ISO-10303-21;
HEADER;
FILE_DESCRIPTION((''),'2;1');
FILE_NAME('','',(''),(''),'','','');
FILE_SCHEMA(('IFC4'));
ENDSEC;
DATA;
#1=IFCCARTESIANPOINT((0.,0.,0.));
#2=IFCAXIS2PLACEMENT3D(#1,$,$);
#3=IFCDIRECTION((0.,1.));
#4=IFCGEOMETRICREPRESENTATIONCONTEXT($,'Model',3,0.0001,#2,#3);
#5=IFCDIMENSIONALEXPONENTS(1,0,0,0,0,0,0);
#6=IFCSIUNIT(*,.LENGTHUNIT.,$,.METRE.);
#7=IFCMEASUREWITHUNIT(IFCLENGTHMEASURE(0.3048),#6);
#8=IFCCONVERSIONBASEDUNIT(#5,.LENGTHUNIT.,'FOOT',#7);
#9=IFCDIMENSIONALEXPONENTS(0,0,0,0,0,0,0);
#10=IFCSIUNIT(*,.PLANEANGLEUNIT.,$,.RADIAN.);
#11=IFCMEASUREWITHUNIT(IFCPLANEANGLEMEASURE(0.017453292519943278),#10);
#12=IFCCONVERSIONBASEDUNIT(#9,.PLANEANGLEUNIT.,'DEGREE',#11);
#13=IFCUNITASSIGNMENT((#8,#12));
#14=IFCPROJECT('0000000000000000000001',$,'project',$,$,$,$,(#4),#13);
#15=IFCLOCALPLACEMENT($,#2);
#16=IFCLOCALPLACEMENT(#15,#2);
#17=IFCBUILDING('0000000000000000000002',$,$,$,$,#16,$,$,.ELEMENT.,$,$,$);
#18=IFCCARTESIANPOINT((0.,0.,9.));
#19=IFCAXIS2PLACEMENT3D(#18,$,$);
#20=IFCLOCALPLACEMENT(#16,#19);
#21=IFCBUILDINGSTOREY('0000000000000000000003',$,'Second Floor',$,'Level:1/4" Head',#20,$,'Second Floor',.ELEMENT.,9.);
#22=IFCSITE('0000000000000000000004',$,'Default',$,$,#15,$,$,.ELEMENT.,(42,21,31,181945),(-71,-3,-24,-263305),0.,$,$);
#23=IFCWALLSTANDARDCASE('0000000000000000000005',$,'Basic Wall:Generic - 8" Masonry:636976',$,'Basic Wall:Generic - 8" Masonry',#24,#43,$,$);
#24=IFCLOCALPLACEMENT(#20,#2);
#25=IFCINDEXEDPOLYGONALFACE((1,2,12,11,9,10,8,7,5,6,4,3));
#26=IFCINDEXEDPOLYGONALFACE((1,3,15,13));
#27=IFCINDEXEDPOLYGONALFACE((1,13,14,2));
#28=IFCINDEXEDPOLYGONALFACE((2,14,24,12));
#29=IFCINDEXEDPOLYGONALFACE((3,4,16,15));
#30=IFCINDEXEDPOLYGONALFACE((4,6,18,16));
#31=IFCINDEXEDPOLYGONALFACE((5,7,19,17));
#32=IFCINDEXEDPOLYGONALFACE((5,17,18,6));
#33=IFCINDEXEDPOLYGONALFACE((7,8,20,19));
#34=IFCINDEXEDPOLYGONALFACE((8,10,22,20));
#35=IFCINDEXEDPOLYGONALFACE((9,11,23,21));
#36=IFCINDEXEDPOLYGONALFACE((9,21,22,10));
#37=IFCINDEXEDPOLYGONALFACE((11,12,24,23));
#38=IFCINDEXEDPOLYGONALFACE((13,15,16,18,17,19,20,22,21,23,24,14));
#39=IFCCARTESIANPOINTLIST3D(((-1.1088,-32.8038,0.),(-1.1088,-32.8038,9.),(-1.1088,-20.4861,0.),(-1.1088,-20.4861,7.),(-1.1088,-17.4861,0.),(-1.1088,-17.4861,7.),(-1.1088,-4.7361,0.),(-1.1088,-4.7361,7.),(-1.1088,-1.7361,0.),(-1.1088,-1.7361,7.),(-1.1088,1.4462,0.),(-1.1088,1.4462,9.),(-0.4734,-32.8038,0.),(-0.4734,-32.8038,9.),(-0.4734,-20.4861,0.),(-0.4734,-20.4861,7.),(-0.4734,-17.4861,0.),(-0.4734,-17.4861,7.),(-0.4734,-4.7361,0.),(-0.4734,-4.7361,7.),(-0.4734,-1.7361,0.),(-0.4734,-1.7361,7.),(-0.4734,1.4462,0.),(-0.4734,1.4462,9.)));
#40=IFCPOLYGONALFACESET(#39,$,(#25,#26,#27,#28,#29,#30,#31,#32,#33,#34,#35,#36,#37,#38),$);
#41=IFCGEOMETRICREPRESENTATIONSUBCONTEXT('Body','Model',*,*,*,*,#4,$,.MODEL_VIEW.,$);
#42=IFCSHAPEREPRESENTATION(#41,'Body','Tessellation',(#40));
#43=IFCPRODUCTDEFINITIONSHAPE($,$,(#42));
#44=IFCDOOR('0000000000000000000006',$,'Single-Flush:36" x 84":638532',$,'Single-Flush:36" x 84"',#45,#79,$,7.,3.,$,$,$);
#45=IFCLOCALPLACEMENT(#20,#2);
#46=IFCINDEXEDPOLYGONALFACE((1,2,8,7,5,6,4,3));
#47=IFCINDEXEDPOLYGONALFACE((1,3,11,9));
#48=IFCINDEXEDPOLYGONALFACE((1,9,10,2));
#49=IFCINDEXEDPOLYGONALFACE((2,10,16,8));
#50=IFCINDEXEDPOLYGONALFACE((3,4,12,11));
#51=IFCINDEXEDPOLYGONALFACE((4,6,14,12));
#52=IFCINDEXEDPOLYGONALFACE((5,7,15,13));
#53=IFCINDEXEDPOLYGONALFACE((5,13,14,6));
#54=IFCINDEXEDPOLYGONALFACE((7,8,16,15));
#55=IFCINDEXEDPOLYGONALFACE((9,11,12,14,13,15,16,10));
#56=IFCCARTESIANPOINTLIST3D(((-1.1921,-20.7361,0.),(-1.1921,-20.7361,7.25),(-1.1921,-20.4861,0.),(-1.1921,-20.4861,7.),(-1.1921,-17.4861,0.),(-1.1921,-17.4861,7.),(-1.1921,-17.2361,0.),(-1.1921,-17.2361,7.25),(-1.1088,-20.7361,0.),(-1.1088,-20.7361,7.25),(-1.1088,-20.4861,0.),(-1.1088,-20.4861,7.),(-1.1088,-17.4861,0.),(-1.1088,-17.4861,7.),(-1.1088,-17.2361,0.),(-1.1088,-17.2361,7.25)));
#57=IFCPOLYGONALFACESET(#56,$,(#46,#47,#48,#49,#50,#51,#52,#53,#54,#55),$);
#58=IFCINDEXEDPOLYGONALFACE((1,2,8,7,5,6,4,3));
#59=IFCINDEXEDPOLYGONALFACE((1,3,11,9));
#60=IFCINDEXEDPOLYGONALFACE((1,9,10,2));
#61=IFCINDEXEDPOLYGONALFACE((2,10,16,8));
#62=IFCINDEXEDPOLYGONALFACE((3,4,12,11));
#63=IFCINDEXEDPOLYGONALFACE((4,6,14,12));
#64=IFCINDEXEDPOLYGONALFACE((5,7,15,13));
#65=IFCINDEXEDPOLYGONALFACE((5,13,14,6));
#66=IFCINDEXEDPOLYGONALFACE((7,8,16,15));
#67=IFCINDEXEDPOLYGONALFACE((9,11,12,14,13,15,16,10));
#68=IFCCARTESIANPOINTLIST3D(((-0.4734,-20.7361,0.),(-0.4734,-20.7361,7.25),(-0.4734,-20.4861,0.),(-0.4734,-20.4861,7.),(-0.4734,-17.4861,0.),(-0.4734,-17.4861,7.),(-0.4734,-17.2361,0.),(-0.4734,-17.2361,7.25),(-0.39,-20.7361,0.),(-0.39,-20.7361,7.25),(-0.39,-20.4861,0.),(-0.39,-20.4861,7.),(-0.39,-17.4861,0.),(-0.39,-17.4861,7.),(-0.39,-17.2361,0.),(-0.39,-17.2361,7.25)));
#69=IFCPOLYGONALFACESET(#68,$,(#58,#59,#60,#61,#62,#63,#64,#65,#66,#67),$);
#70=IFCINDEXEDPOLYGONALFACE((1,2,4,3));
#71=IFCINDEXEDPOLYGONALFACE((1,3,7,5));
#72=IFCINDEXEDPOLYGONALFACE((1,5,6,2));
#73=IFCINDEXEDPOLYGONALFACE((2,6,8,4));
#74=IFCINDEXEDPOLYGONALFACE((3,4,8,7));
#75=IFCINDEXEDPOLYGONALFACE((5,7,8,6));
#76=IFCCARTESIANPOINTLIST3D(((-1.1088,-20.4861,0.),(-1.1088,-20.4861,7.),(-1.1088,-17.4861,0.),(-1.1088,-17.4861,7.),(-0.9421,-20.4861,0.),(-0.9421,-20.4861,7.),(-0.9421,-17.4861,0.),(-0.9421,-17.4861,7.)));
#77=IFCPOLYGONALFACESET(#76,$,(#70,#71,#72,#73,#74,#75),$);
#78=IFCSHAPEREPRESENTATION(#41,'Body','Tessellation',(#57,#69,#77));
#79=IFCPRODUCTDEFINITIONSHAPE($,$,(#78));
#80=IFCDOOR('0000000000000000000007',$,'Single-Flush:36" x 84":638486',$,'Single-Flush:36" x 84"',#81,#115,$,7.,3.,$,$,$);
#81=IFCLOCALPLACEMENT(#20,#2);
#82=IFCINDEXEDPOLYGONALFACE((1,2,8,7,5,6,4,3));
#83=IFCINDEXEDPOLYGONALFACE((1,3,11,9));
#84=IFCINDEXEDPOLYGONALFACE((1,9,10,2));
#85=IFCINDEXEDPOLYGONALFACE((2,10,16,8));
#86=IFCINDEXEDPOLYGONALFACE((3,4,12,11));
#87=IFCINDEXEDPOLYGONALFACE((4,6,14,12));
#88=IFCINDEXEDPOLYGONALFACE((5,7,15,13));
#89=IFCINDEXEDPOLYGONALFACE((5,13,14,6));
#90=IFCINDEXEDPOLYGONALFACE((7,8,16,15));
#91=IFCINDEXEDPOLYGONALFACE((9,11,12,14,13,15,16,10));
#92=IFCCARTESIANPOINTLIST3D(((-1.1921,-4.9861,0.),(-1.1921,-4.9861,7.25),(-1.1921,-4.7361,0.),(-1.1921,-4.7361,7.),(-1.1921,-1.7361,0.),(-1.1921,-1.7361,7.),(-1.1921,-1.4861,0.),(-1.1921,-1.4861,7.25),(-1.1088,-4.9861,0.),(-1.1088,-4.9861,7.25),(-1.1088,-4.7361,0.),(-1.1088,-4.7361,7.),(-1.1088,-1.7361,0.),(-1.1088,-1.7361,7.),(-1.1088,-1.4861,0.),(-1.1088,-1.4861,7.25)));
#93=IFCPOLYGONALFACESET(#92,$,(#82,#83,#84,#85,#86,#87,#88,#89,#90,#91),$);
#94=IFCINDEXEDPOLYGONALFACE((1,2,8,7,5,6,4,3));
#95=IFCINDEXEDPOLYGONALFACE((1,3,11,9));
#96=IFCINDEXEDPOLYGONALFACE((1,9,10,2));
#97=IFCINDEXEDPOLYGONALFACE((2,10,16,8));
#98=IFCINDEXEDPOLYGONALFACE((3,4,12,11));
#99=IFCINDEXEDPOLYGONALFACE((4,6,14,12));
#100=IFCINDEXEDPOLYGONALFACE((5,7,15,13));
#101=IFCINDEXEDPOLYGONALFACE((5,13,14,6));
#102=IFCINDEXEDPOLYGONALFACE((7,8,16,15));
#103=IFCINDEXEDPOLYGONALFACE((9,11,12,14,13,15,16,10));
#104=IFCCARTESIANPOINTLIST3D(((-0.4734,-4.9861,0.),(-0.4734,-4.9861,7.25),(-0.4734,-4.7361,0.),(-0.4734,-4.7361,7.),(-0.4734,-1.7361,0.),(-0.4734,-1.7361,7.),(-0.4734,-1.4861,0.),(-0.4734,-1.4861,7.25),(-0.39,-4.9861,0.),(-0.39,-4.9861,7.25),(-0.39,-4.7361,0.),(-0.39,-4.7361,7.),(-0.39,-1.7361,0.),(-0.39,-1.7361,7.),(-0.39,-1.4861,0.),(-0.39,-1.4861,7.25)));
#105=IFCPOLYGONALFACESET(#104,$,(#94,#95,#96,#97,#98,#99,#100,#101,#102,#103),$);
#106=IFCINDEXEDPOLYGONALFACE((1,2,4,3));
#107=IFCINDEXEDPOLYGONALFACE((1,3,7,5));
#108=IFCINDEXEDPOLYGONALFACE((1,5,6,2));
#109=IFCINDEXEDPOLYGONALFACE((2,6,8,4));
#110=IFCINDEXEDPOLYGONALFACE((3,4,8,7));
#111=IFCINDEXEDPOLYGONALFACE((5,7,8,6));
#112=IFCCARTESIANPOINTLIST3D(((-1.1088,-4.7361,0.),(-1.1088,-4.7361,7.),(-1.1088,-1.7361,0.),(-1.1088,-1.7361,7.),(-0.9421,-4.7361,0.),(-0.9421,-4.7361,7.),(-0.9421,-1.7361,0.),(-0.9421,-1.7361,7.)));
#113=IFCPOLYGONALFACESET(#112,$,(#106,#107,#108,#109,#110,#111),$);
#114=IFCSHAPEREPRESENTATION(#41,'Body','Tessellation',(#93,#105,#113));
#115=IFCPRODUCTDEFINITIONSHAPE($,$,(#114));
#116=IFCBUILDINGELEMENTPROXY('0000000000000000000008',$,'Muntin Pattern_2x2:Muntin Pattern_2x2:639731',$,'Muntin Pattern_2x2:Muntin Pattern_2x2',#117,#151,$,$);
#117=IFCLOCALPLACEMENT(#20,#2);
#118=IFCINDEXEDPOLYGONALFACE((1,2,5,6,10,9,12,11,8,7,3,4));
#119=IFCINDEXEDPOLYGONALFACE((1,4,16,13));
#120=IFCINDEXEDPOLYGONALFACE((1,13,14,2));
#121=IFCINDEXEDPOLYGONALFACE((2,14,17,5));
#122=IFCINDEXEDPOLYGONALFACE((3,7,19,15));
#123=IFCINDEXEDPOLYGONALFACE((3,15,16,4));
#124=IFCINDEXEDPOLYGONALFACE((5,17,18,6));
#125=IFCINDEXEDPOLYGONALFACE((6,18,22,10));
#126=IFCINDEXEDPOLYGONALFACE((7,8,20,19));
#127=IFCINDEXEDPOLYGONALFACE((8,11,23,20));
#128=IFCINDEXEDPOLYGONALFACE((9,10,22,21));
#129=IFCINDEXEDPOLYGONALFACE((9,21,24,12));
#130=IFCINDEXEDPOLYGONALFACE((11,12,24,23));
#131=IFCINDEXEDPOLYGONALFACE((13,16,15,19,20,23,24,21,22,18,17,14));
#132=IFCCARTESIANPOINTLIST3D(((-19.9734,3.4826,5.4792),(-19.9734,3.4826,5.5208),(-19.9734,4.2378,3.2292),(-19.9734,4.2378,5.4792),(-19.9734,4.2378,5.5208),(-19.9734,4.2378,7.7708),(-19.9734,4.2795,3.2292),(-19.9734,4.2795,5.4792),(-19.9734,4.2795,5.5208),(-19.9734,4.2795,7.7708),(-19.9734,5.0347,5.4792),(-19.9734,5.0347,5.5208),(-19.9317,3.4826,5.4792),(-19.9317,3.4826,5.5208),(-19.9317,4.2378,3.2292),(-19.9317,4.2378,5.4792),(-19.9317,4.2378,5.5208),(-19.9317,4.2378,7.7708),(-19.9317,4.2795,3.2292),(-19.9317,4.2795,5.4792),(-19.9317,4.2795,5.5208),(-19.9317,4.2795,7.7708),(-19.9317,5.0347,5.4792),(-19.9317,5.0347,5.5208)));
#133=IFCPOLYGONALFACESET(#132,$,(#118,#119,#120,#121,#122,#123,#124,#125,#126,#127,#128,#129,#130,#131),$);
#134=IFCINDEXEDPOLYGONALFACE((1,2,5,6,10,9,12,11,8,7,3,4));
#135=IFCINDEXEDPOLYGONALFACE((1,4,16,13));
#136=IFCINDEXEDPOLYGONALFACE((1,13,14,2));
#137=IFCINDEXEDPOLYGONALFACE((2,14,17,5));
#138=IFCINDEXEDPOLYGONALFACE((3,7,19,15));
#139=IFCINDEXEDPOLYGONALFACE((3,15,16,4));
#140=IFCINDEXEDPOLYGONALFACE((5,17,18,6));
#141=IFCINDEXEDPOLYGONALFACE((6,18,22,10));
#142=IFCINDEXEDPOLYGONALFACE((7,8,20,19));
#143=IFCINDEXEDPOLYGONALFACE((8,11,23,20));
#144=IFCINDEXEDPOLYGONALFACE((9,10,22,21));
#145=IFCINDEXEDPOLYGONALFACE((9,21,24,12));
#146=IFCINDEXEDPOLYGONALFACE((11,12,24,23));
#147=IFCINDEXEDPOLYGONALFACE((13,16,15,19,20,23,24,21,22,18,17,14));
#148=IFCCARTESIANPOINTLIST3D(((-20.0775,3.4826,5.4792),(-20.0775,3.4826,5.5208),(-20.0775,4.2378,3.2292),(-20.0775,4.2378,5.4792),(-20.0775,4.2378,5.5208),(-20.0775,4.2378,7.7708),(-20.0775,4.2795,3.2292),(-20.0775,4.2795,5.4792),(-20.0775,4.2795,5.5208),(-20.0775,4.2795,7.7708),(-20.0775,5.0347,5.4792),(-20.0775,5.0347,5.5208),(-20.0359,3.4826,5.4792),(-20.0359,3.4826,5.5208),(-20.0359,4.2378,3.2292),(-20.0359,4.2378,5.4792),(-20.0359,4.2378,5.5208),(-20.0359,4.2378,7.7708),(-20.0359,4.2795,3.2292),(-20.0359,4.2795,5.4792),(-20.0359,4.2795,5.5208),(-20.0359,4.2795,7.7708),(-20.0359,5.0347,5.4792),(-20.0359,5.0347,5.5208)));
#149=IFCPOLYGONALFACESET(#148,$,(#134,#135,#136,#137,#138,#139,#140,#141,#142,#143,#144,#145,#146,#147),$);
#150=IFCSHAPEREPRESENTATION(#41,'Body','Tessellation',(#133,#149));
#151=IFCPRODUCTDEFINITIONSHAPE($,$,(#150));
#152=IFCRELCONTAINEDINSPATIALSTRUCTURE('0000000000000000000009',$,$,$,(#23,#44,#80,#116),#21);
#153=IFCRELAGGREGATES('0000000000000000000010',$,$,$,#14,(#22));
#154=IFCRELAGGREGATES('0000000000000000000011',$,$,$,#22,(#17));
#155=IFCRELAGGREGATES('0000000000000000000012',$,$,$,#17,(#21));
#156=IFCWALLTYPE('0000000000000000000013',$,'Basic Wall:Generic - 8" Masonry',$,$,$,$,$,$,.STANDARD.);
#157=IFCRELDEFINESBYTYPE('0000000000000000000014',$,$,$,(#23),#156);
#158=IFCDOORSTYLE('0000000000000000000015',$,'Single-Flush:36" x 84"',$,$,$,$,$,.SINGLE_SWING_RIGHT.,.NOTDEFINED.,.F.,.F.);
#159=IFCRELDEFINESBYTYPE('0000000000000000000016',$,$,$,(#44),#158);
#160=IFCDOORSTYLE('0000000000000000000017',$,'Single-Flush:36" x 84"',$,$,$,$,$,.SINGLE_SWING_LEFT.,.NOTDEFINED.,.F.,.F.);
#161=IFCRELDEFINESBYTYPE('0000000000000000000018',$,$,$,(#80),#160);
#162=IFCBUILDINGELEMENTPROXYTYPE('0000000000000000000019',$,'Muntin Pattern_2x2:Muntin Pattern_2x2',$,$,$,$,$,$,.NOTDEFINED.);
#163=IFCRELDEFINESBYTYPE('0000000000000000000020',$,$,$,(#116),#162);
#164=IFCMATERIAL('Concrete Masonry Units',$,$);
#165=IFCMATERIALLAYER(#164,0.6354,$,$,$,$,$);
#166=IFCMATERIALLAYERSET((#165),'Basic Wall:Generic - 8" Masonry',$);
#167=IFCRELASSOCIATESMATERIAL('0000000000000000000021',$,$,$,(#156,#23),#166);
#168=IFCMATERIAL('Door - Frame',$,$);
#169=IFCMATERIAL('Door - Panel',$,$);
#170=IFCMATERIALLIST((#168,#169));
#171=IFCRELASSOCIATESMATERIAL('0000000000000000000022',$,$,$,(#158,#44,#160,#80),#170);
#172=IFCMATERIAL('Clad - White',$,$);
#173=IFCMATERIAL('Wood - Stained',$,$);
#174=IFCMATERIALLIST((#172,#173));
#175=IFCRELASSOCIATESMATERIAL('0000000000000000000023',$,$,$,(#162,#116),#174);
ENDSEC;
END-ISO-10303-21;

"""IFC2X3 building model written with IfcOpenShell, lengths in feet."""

from ifc_helpers import new_model, entity, si_unit, converted_unit, direction, frame, frame_2d, origin, place, context, subcontext, project, spatial, polyline, rectangle, outline, extrude, source, transform, mapped, material, material_list, layer, layer_set, layer_usage, type_object, type_shapes, element, fill, save


model = new_model("IFC2X3")

# Units and contexts
model_context = context("Model", 3, precision=0.0001, world=origin(), true_north=direction((0.0, 1.0)))
body_context = subcontext(model_context, "Body", "Model", "MODEL_VIEW")
ifc_project = project(units=[converted_unit("LENGTHUNIT", "FOOT", entity("IfcLengthMeasure", 0.3048), si_unit("LENGTHUNIT", "METRE"), dimensions=[1, 0, 0, 0, 0, 0, 0]), converted_unit("PLANEANGLEUNIT", "DEGREE", entity("IfcPlaneAngleMeasure", 0.017453292519943278), si_unit("PLANEANGLEUNIT", "RADIAN"), dimensions=[0, 0, 0, 0, 0, 0, 0])], contexts=[model_context])

# Site, building, storey
site_placement = place(None, origin())
site = spatial("IfcSite", under=ifc_project, at=site_placement, Name="Default", CompositionType="ELEMENT", RefLatitude=(42, 21, 31, 181945), RefLongitude=(-71, -3, -24, -263305), RefElevation=0.0)
building_placement = place(site_placement, origin())
building = spatial("IfcBuilding", under=site, at=building_placement, CompositionType="ELEMENT")
storey_placement = place(building_placement, frame((0.0, 0.0, 9.0)))
storey = spatial("IfcBuildingStorey", under=building, at=storey_placement, Name="Second Floor", ObjectType="Level:1/4\" Head", LongName="Second Floor", CompositionType="ELEMENT", Elevation=9.0)

# Shared definitions
ifc_material_1 = material(Name="Concrete Masonry Units")
ifc_layer = layer(ifc_material_1, 0.6354)
ifc_layer_set = layer_set([ifc_layer], Name="Basic Wall:Generic - 8\" Masonry")
wall_type = type_object("IfcWallType", Name="Basic Wall:Generic - 8\" Masonry", PredefinedType="STANDARD", material=ifc_layer_set)

# Shared definitions
ifc_material_2 = material(Name="Door - Frame")
ifc_material_3 = material(Name="Door - Panel")
ifc_material_list_1 = material_list([ifc_material_2, ifc_material_3])
door_style_1 = type_object("IfcDoorStyle", Name="Single-Flush:36\" x 84\"", ConstructionType="NOTDEFINED", OperationType="SINGLE_SWING_RIGHT", ParameterTakesPrecedence=False, Sizeable=False, material=ifc_material_list_1)
shared_shape_1 = source(origin(), body_context, "Body", "SweptSolid", [
    extrude(outline(polyline([(-1.75, -3.6875), (1.75, -3.6875), (1.75, 3.5625), (1.5, 3.5625), (1.5, -3.4375), (-1.5, -3.4375), (-1.5, 3.5625), (-1.75, 3.5625), (-1.75, -3.6875)])), frame((1.5, 0.6354, 3.5625), z_axis=(0.0, 1.0, 0.0), x_axis=(1.0, 0.0, 0.0)), (0.0, 0.0, 1.0), 0.0833),
    extrude(outline(polyline([(-3.6875, -1.75), (3.5625, -1.75), (3.5625, -1.5), (-3.4375, -1.5), (-3.4375, 1.5), (3.5625, 1.5), (3.5625, 1.75), (-3.6875, 1.75), (-3.6875, -1.75)])), frame((1.5, -0.0833, 3.5625), z_axis=(0.0, 1.0, 0.0), x_axis=(0.0, 0.0, -1.0)), (0.0, 0.0, 1.0), 0.0833),
    extrude(rectangle(XDim=0.1667, YDim=3.0, at=frame_2d((0.0, 0.0), x_axis=(1.0, 0.0))), frame((1.5, 0.5521, 0.0), z_axis=(0.0, 0.0, 1.0), x_axis=(0.0, 1.0, 0.0)), (0.0, 0.0, 1.0), 7.0),
])
type_shapes(door_style_1, [shared_shape_1])

# Wall, openings, doors
ifc_layer_usage_1 = layer_usage(ifc_layer_set, "AXIS2", "NEGATIVE", 0.3177)
wall_1_placement = place(storey_placement, frame((-0.7911, 1.4462, 0.0), z_axis=(0.0, 0.0, 1.0), x_axis=(0.0, -1.0, 0.0)))
wall_1 = element("IfcWallStandardCase", 1, at=wall_1_placement, inside=storey, type_object=wall_type, material=ifc_layer_usage_1, Name="Basic Wall:Generic - 8\" Masonry:636976", ObjectType="Basic Wall:Generic - 8\" Masonry", context=body_context, shape_type="SweptSolid", body=[
    extrude(rectangle(XDim=34.25, YDim=0.6354, at=frame_2d((17.125, 0.0), x_axis=(1.0, 0.0))), origin(), (0.0, 0.0, 1.0), 9.0),
])
opening_1_placement = place(wall_1_placement, frame((6.1823, 0.3177, 0.0)))
opening_1 = element("IfcOpeningElement", 2, at=opening_1_placement, cuts=wall_1, ObjectType="Opening", context=body_context, shape_type="SweptSolid", body=[
    extrude(rectangle(XDim=3.0, YDim=7.0, at=frame_2d((3.5, 1.5), x_axis=(0.0, -1.0))), frame((0.0, 0.0, 0.0), z_axis=(0.0, -1.0, 0.0), x_axis=(0.0, 0.0, 1.0)), (0.0, 0.0, 1.0), 0.6354),
])
opening_2_placement = place(wall_1_placement, frame((21.9323, 0.3177, 0.0)))
opening_2 = element("IfcOpeningElement", 3, at=opening_2_placement, cuts=wall_1, ObjectType="Opening", context=body_context, shape_type="SweptSolid", body=[
    extrude(rectangle(XDim=3.0, YDim=7.0, at=frame_2d((3.5, 1.5), x_axis=(0.0, 1.0))), frame((0.0, 0.0, 0.0), z_axis=(0.0, -1.0, 0.0), x_axis=(0.0, 0.0, 1.0)), (0.0, 0.0, 1.0), 0.6354),
])
door_1_placement = place(opening_2_placement, frame((0.0, 0.0, 0.0), z_axis=(0.0, 0.0, 1.0), x_axis=(-1.0, 0.0, 0.0)))
door_1 = element("IfcDoor", 4, at=door_1_placement, inside=storey, type_object=door_style_1, material=ifc_material_list_1, Name="Single-Flush:36\" x 84\":638532", ObjectType="Single-Flush:36\" x 84\"", OverallHeight=7.0, OverallWidth=3.0, context=body_context, shape_type="MappedRepresentation", body=[
    mapped(shared_shape_1, transform((0.0, 0.0, 0.0), scale=1.0)),
])
fill(opening_2, door_1)
door_style_2 = type_object("IfcDoorStyle", Name="Single-Flush:36\" x 84\"", ConstructionType="NOTDEFINED", OperationType="SINGLE_SWING_LEFT", ParameterTakesPrecedence=False, Sizeable=False, material=ifc_material_list_1)
shared_shape_2 = source(origin(), body_context, "Body", "SweptSolid", [
    extrude(outline(polyline([(-1.75, -3.6875), (1.75, -3.6875), (1.75, 3.5625), (1.5, 3.5625), (1.5, -3.4375), (-1.5, -3.4375), (-1.5, 3.5625), (-1.75, 3.5625), (-1.75, -3.6875)])), frame((1.5, 0.7187, 3.5625), z_axis=(0.0, -1.0, 0.0), x_axis=(-1.0, 0.0, 0.0)), (0.0, 0.0, 1.0), 0.0833),
    extrude(outline(polyline([(-3.6875, -1.75), (3.5625, -1.75), (3.5625, -1.5), (-3.4375, -1.5), (-3.4375, 1.5), (3.5625, 1.5), (3.5625, 1.75), (-3.6875, 1.75), (-3.6875, -1.75)])), frame((1.5, 0.0, 3.5625), z_axis=(0.0, -1.0, 0.0), x_axis=(0.0, 0.0, -1.0)), (0.0, 0.0, 1.0), 0.0833),
    extrude(rectangle(XDim=3.0, YDim=0.1667, at=frame_2d((0.0, 0.0), x_axis=(1.0, 0.0))), frame((1.5, 0.5521, 0.0)), (0.0, 0.0, 1.0), 7.0),
])
type_shapes(door_style_2, [shared_shape_2])
door_2_placement = place(opening_1_placement, frame((0.0, 0.0, 0.0), z_axis=(0.0, 0.0, 1.0), x_axis=(-1.0, 0.0, 0.0)))
door_2 = element("IfcDoor", 5, at=door_2_placement, inside=storey, type_object=door_style_2, material=ifc_material_list_1, Name="Single-Flush:36\" x 84\":638486", ObjectType="Single-Flush:36\" x 84\"", OverallHeight=7.0, OverallWidth=3.0, context=body_context, shape_type="MappedRepresentation", body=[
    mapped(shared_shape_2, transform((0.0, 0.0, 0.0), scale=1.0)),
])
fill(opening_1, door_2)

# Building element proxy
ifc_material_4 = material(Name="Clad - White")
ifc_material_5 = material(Name="Wood - Stained")
ifc_material_list_2 = material_list([ifc_material_4, ifc_material_5])
building_element_proxy_type_1 = type_object("IfcBuildingElementProxyType", Name="Muntin Pattern_2x2:Muntin Pattern_2x2", PredefinedType="NOTDEFINED", material=ifc_material_list_2)
shared_shape_3 = source(origin(), body_context, "Body", "SweptSolid", [
    extrude(outline(polyline([(0.0208, -0.0208), (2.2708, -0.0208), (2.2708, 0.0208), (0.0208, 0.0208), (0.0208, 0.776), (-0.0208, 0.776), (-0.0208, 0.0208), (-2.2708, 0.0208), (-2.2708, -0.0208), (-0.0208, -0.0208), (-0.0208, -0.776), (0.0208, -0.776), (0.0208, -0.0208)])), frame((0.0, 0.0313, 2.2708), z_axis=(0.0, 1.0, 0.0), x_axis=(0.0, 0.0, 1.0)), (0.0, 0.0, 1.0), 0.0417),
    extrude(outline(polyline([(0.0208, -0.0208), (2.2708, -0.0208), (2.2708, 0.0208), (0.0208, 0.0208), (0.0208, 0.776), (-0.0208, 0.776), (-0.0208, 0.0208), (-2.2708, 0.0208), (-2.2708, -0.0208), (-0.0208, -0.0208), (-0.0208, -0.776), (0.0208, -0.776), (0.0208, -0.0208)])), frame((0.0, -0.0729, 2.2708), z_axis=(0.0, 1.0, 0.0), x_axis=(0.0, 0.0, 1.0)), (0.0, 0.0, 1.0), 0.0417),
])
type_shapes(building_element_proxy_type_1, [shared_shape_3])
proxy_1_placement = place(storey_placement, frame((-20.0046, 4.2587, 3.2292), z_axis=(0.0, 0.0, 1.0), x_axis=(0.0, -1.0, 0.0)))
element("IfcBuildingElementProxy", 6, at=proxy_1_placement, inside=storey, type_object=building_element_proxy_type_1, material=ifc_material_list_2, Name="Muntin Pattern_2x2:Muntin Pattern_2x2:639731", ObjectType="Muntin Pattern_2x2:Muntin Pattern_2x2", context=body_context, shape_type="MappedRepresentation", body=[
    mapped(shared_shape_3, transform((0.0, 0.0, 0.0), scale=1.0)),
])

save(model, "model.ifc")
